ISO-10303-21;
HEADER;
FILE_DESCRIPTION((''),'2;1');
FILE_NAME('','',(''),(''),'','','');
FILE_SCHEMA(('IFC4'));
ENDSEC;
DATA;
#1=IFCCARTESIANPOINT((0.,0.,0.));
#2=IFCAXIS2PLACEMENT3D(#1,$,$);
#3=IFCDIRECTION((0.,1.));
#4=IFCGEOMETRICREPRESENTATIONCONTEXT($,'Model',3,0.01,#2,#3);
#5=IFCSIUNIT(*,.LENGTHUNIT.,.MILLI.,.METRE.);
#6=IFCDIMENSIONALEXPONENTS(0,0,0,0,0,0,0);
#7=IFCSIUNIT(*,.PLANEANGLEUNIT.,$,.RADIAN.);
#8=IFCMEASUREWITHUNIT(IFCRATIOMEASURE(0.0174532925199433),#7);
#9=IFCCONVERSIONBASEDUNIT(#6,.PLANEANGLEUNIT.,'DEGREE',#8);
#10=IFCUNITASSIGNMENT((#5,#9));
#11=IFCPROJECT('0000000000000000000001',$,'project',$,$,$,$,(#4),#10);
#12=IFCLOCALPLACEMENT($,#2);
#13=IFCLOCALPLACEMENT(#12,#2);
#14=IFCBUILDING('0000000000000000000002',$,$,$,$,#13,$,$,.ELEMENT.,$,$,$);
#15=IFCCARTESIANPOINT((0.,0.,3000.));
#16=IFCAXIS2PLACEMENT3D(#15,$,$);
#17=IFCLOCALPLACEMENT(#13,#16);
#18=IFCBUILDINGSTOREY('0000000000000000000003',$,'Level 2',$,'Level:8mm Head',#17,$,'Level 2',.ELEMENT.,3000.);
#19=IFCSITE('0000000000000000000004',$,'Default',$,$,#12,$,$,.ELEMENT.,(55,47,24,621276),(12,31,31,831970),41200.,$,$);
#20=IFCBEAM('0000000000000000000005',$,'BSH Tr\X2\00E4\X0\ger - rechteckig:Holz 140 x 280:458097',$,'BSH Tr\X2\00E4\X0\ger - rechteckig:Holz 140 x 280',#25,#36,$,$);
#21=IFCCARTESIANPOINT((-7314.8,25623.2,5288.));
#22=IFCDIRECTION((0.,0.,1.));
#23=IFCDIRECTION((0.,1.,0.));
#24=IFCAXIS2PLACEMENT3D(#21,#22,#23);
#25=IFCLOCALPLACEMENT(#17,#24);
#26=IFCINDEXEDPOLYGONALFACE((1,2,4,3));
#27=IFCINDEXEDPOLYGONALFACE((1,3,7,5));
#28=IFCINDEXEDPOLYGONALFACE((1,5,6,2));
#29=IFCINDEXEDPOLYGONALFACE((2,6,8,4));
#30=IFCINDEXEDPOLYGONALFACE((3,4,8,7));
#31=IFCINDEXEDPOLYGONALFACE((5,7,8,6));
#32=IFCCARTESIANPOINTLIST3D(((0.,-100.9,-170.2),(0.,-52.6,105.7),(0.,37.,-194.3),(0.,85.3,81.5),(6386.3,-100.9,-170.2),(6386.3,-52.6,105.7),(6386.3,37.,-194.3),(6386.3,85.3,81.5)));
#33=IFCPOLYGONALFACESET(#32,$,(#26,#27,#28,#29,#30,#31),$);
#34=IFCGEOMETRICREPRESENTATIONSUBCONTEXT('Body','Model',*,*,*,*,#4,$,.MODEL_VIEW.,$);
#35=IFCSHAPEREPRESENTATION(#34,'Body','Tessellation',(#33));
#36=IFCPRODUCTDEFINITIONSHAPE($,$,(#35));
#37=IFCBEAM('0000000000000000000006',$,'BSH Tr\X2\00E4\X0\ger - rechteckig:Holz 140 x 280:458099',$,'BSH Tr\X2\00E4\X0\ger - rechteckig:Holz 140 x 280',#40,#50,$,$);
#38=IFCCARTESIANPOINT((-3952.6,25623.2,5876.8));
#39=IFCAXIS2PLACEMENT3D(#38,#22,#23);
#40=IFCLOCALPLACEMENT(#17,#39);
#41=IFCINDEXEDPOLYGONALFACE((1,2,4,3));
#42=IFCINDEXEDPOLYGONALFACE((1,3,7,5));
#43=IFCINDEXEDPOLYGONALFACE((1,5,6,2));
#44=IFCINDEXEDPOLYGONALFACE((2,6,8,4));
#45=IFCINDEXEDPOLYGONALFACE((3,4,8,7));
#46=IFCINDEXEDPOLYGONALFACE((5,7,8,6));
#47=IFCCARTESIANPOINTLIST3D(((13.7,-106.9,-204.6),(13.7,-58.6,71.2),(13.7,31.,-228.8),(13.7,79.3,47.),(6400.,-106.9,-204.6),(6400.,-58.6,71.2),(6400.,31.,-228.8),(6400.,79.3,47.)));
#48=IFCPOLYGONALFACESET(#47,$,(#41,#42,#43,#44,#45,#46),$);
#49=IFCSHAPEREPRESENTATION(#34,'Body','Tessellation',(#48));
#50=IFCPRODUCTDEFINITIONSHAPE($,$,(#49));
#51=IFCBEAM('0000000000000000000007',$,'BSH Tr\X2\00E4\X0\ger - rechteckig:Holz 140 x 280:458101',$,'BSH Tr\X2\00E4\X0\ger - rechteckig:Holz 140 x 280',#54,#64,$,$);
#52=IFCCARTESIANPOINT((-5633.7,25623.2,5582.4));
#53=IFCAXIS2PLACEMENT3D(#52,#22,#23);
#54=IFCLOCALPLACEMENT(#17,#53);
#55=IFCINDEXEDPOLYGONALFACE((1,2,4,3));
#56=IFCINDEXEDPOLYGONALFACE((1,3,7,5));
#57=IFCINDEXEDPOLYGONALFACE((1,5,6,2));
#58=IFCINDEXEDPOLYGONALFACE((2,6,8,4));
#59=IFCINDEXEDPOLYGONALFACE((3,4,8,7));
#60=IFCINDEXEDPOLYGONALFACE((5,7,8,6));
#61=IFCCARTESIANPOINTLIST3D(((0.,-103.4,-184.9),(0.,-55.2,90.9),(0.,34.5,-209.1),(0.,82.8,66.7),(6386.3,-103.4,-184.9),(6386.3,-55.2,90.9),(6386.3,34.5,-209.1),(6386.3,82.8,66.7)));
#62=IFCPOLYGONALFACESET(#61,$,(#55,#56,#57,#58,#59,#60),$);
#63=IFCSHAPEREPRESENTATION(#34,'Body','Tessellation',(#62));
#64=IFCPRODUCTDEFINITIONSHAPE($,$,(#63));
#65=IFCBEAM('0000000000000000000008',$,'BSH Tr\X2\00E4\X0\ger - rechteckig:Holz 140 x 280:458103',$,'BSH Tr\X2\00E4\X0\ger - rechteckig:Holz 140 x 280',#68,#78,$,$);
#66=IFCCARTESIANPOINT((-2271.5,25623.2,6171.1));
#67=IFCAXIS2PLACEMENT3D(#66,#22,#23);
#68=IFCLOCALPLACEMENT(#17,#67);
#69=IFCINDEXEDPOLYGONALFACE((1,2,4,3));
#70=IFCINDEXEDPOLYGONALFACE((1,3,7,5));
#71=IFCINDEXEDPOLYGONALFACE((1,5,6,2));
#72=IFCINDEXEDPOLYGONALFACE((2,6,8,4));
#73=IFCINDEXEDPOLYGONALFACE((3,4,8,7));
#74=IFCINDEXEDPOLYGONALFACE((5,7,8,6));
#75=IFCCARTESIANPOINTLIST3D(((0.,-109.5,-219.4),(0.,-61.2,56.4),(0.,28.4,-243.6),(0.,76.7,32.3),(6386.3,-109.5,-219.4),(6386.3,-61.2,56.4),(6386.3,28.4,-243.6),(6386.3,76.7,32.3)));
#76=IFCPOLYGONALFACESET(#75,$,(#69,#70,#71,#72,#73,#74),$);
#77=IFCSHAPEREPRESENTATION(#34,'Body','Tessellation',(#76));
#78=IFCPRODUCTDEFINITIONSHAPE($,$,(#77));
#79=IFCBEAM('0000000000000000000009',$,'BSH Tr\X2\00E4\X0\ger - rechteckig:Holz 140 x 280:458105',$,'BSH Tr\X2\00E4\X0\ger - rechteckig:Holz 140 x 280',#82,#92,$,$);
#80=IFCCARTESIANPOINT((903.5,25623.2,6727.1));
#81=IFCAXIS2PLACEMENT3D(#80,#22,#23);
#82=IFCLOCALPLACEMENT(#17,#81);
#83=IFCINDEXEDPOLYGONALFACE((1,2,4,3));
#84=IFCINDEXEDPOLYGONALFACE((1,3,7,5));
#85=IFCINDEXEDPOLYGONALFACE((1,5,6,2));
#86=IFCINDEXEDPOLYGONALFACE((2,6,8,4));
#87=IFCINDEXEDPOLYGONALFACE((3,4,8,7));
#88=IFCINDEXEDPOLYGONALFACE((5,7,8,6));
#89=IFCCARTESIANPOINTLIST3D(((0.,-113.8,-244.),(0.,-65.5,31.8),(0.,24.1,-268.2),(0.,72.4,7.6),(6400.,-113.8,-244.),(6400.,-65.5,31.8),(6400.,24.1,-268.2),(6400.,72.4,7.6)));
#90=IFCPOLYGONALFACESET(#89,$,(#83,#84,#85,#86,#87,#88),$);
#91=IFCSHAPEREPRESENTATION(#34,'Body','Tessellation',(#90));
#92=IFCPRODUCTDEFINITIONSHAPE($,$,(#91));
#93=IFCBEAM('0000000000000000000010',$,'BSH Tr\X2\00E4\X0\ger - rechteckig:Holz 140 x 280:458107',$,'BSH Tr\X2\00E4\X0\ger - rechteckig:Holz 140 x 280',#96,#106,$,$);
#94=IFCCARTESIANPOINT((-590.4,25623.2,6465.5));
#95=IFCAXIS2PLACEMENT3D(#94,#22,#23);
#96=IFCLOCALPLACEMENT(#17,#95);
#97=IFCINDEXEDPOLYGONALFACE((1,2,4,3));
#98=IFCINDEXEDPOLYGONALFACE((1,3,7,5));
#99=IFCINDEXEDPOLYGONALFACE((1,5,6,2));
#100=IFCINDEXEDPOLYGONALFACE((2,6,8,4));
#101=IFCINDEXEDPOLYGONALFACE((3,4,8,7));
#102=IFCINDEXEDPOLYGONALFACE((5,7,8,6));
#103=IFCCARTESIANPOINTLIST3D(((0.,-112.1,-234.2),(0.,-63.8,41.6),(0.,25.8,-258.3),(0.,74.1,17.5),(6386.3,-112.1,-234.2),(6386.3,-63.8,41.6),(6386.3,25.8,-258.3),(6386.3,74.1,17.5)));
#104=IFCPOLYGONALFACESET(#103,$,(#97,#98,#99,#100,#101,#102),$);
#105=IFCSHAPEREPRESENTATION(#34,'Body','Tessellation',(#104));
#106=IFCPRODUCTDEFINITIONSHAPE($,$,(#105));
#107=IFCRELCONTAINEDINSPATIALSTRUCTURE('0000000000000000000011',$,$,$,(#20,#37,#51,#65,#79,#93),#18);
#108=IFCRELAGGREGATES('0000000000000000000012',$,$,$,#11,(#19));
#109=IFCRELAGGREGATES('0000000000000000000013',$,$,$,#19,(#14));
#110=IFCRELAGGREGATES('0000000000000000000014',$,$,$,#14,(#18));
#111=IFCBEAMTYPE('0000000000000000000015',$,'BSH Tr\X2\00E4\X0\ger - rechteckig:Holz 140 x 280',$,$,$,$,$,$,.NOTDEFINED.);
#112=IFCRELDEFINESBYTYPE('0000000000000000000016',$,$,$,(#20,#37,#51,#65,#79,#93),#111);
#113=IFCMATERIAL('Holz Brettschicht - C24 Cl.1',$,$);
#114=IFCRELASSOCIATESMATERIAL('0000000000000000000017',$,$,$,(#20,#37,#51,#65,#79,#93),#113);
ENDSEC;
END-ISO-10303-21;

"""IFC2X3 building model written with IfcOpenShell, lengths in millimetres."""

from ifc_helpers import new_model, entity, si_unit, converted_unit, direction, frame, frame_2d, origin, origin_2d_with_axis, place, context, subcontext, project, spatial, rectangle, extrude, material, type_object, element, save


model = new_model("IFC2X3")

# Units and contexts
model_context = context("Model", 3, precision=0.01, world=origin(), true_north=direction((0.0, 1.0)))
body_context = subcontext(model_context, "Body", "Model", "MODEL_VIEW")
ifc_project = project(units=[si_unit("LENGTHUNIT", "METRE", prefix="MILLI"), converted_unit("PLANEANGLEUNIT", "DEGREE", entity("IfcRatioMeasure", 0.0174532925199433), si_unit("PLANEANGLEUNIT", "RADIAN"), dimensions=[0, 0, 0, 0, 0, 0, 0])], contexts=[model_context])

# Site, building, storey
site_placement = place(None, origin())
site = spatial("IfcSite", under=ifc_project, at=site_placement, Name="Default", CompositionType="ELEMENT", RefLatitude=(55, 47, 24, 621276), RefLongitude=(12, 31, 31, 831970), RefElevation=41200.0)
building_placement = place(site_placement, origin())
building = spatial("IfcBuilding", under=site, at=building_placement, CompositionType="ELEMENT")
storey_placement = place(building_placement, frame((0.0, 0.0, 3000.0)))
storey = spatial("IfcBuildingStorey", under=building, at=storey_placement, Name="Level 2", ObjectType="Level:8mm Head", LongName="Level 2", CompositionType="ELEMENT", Elevation=3000.0)

# Beams
ifc_material = material(Name="Holz Brettschicht - C24 Cl.1")
beam_type_1 = type_object("IfcBeamType", Name="BSH Träger - rechteckig:Holz 140 x 280", PredefinedType="NOTDEFINED")
beam_1_placement = place(storey_placement, frame((-7314.8, 25623.2, 5288.0), z_axis=(0.0, 0.0, 1.0), x_axis=(0.0, 1.0, 0.0)))
element("IfcBeam", 1, at=beam_1_placement, inside=storey, type_object=beam_type_1, material=ifc_material, Name="BSH Träger - rechteckig:Holz 140 x 280:458097", ObjectType="BSH Träger - rechteckig:Holz 140 x 280", context=body_context, shape_type="SweptSolid", body=[
    extrude(rectangle(XDim=280.0, YDim=140.0, at=origin_2d_with_axis()), frame((0.0, -7.8, -44.3), z_axis=(1.0, 0.0, 0.0), x_axis=(0.0, 0.172491, 0.985011)), (0.0, 0.0, 1.0), 6386.3),
])
beam_2_placement = place(storey_placement, frame((-3952.6, 25623.2, 5876.8), z_axis=(0.0, 0.0, 1.0), x_axis=(0.0, 1.0, 0.0)))
element("IfcBeam", 2, at=beam_2_placement, inside=storey, type_object=beam_type_1, material=ifc_material, Name="BSH Träger - rechteckig:Holz 140 x 280:458099", ObjectType="BSH Träger - rechteckig:Holz 140 x 280", context=body_context, shape_type="SweptSolid", body=[
    extrude(rectangle(XDim=280.0, YDim=140.0, at=origin_2d_with_axis()), frame((13.7, -13.8, -78.8), z_axis=(1.0, 0.0, 0.0), x_axis=(0.0, 0.172491, 0.985011)), (0.0, 0.0, 1.0), 6386.3),
])
beam_3_placement = place(storey_placement, frame((-5633.7, 25623.2, 5582.4), z_axis=(0.0, 0.0, 1.0), x_axis=(0.0, 1.0, 0.0)))
element("IfcBeam", 3, at=beam_3_placement, inside=storey, type_object=beam_type_1, material=ifc_material, Name="BSH Träger - rechteckig:Holz 140 x 280:458101", ObjectType="BSH Träger - rechteckig:Holz 140 x 280", context=body_context, shape_type="SweptSolid", body=[
    extrude(rectangle(XDim=280.0, YDim=140.0, at=origin_2d_with_axis()), frame((0.0, -10.3, -59.1), z_axis=(1.0, 0.0, 0.0), x_axis=(0.0, 0.172491, 0.985011)), (0.0, 0.0, 1.0), 6386.3),
])
beam_4_placement = place(storey_placement, frame((-2271.5, 25623.2, 6171.1), z_axis=(0.0, 0.0, 1.0), x_axis=(0.0, 1.0, 0.0)))
element("IfcBeam", 4, at=beam_4_placement, inside=storey, type_object=beam_type_1, material=ifc_material, Name="BSH Träger - rechteckig:Holz 140 x 280:458103", ObjectType="BSH Träger - rechteckig:Holz 140 x 280", context=body_context, shape_type="SweptSolid", body=[
    extrude(rectangle(XDim=280.0, YDim=140.0, at=origin_2d_with_axis()), frame((0.0, -16.4, -93.6), z_axis=(1.0, 0.0, 0.0), x_axis=(0.0, 0.172491, 0.985011)), (0.0, 0.0, 1.0), 6386.3),
])
beam_5_placement = place(storey_placement, frame((903.5, 25623.2, 6727.1), z_axis=(0.0, 0.0, 1.0), x_axis=(0.0, 1.0, 0.0)))
element("IfcBeam", 5, at=beam_5_placement, inside=storey, type_object=beam_type_1, material=ifc_material, Name="BSH Träger - rechteckig:Holz 140 x 280:458105", ObjectType="BSH Träger - rechteckig:Holz 140 x 280", context=body_context, shape_type="SweptSolid", body=[
    extrude(rectangle(XDim=280.0, YDim=140.0, at=frame_2d((0.0, 0.0), x_axis=(1.0, 0.0))), frame((0.0, -20.7, -118.2), z_axis=(1.0, 0.0, 0.0), x_axis=(0.0, 0.172491, 0.985011)), (0.0, 0.0, 1.0), 6400.0),
])
beam_6_placement = place(storey_placement, frame((-590.4, 25623.2, 6465.5), z_axis=(0.0, 0.0, 1.0), x_axis=(0.0, 1.0, 0.0)))
element("IfcBeam", 6, at=beam_6_placement, inside=storey, type_object=beam_type_1, material=ifc_material, Name="BSH Träger - rechteckig:Holz 140 x 280:458107", ObjectType="BSH Träger - rechteckig:Holz 140 x 280", context=body_context, shape_type="SweptSolid", body=[
    extrude(rectangle(XDim=280.0, YDim=140.0, at=frame_2d((0.0, 0.0), x_axis=(1.0, 0.0))), frame((0.0, -19.0, -108.4), z_axis=(1.0, 0.0, 0.0), x_axis=(0.0, 0.172491, 0.985011)), (0.0, 0.0, 1.0), 6386.3),
])

save(model, "model.ifc")
